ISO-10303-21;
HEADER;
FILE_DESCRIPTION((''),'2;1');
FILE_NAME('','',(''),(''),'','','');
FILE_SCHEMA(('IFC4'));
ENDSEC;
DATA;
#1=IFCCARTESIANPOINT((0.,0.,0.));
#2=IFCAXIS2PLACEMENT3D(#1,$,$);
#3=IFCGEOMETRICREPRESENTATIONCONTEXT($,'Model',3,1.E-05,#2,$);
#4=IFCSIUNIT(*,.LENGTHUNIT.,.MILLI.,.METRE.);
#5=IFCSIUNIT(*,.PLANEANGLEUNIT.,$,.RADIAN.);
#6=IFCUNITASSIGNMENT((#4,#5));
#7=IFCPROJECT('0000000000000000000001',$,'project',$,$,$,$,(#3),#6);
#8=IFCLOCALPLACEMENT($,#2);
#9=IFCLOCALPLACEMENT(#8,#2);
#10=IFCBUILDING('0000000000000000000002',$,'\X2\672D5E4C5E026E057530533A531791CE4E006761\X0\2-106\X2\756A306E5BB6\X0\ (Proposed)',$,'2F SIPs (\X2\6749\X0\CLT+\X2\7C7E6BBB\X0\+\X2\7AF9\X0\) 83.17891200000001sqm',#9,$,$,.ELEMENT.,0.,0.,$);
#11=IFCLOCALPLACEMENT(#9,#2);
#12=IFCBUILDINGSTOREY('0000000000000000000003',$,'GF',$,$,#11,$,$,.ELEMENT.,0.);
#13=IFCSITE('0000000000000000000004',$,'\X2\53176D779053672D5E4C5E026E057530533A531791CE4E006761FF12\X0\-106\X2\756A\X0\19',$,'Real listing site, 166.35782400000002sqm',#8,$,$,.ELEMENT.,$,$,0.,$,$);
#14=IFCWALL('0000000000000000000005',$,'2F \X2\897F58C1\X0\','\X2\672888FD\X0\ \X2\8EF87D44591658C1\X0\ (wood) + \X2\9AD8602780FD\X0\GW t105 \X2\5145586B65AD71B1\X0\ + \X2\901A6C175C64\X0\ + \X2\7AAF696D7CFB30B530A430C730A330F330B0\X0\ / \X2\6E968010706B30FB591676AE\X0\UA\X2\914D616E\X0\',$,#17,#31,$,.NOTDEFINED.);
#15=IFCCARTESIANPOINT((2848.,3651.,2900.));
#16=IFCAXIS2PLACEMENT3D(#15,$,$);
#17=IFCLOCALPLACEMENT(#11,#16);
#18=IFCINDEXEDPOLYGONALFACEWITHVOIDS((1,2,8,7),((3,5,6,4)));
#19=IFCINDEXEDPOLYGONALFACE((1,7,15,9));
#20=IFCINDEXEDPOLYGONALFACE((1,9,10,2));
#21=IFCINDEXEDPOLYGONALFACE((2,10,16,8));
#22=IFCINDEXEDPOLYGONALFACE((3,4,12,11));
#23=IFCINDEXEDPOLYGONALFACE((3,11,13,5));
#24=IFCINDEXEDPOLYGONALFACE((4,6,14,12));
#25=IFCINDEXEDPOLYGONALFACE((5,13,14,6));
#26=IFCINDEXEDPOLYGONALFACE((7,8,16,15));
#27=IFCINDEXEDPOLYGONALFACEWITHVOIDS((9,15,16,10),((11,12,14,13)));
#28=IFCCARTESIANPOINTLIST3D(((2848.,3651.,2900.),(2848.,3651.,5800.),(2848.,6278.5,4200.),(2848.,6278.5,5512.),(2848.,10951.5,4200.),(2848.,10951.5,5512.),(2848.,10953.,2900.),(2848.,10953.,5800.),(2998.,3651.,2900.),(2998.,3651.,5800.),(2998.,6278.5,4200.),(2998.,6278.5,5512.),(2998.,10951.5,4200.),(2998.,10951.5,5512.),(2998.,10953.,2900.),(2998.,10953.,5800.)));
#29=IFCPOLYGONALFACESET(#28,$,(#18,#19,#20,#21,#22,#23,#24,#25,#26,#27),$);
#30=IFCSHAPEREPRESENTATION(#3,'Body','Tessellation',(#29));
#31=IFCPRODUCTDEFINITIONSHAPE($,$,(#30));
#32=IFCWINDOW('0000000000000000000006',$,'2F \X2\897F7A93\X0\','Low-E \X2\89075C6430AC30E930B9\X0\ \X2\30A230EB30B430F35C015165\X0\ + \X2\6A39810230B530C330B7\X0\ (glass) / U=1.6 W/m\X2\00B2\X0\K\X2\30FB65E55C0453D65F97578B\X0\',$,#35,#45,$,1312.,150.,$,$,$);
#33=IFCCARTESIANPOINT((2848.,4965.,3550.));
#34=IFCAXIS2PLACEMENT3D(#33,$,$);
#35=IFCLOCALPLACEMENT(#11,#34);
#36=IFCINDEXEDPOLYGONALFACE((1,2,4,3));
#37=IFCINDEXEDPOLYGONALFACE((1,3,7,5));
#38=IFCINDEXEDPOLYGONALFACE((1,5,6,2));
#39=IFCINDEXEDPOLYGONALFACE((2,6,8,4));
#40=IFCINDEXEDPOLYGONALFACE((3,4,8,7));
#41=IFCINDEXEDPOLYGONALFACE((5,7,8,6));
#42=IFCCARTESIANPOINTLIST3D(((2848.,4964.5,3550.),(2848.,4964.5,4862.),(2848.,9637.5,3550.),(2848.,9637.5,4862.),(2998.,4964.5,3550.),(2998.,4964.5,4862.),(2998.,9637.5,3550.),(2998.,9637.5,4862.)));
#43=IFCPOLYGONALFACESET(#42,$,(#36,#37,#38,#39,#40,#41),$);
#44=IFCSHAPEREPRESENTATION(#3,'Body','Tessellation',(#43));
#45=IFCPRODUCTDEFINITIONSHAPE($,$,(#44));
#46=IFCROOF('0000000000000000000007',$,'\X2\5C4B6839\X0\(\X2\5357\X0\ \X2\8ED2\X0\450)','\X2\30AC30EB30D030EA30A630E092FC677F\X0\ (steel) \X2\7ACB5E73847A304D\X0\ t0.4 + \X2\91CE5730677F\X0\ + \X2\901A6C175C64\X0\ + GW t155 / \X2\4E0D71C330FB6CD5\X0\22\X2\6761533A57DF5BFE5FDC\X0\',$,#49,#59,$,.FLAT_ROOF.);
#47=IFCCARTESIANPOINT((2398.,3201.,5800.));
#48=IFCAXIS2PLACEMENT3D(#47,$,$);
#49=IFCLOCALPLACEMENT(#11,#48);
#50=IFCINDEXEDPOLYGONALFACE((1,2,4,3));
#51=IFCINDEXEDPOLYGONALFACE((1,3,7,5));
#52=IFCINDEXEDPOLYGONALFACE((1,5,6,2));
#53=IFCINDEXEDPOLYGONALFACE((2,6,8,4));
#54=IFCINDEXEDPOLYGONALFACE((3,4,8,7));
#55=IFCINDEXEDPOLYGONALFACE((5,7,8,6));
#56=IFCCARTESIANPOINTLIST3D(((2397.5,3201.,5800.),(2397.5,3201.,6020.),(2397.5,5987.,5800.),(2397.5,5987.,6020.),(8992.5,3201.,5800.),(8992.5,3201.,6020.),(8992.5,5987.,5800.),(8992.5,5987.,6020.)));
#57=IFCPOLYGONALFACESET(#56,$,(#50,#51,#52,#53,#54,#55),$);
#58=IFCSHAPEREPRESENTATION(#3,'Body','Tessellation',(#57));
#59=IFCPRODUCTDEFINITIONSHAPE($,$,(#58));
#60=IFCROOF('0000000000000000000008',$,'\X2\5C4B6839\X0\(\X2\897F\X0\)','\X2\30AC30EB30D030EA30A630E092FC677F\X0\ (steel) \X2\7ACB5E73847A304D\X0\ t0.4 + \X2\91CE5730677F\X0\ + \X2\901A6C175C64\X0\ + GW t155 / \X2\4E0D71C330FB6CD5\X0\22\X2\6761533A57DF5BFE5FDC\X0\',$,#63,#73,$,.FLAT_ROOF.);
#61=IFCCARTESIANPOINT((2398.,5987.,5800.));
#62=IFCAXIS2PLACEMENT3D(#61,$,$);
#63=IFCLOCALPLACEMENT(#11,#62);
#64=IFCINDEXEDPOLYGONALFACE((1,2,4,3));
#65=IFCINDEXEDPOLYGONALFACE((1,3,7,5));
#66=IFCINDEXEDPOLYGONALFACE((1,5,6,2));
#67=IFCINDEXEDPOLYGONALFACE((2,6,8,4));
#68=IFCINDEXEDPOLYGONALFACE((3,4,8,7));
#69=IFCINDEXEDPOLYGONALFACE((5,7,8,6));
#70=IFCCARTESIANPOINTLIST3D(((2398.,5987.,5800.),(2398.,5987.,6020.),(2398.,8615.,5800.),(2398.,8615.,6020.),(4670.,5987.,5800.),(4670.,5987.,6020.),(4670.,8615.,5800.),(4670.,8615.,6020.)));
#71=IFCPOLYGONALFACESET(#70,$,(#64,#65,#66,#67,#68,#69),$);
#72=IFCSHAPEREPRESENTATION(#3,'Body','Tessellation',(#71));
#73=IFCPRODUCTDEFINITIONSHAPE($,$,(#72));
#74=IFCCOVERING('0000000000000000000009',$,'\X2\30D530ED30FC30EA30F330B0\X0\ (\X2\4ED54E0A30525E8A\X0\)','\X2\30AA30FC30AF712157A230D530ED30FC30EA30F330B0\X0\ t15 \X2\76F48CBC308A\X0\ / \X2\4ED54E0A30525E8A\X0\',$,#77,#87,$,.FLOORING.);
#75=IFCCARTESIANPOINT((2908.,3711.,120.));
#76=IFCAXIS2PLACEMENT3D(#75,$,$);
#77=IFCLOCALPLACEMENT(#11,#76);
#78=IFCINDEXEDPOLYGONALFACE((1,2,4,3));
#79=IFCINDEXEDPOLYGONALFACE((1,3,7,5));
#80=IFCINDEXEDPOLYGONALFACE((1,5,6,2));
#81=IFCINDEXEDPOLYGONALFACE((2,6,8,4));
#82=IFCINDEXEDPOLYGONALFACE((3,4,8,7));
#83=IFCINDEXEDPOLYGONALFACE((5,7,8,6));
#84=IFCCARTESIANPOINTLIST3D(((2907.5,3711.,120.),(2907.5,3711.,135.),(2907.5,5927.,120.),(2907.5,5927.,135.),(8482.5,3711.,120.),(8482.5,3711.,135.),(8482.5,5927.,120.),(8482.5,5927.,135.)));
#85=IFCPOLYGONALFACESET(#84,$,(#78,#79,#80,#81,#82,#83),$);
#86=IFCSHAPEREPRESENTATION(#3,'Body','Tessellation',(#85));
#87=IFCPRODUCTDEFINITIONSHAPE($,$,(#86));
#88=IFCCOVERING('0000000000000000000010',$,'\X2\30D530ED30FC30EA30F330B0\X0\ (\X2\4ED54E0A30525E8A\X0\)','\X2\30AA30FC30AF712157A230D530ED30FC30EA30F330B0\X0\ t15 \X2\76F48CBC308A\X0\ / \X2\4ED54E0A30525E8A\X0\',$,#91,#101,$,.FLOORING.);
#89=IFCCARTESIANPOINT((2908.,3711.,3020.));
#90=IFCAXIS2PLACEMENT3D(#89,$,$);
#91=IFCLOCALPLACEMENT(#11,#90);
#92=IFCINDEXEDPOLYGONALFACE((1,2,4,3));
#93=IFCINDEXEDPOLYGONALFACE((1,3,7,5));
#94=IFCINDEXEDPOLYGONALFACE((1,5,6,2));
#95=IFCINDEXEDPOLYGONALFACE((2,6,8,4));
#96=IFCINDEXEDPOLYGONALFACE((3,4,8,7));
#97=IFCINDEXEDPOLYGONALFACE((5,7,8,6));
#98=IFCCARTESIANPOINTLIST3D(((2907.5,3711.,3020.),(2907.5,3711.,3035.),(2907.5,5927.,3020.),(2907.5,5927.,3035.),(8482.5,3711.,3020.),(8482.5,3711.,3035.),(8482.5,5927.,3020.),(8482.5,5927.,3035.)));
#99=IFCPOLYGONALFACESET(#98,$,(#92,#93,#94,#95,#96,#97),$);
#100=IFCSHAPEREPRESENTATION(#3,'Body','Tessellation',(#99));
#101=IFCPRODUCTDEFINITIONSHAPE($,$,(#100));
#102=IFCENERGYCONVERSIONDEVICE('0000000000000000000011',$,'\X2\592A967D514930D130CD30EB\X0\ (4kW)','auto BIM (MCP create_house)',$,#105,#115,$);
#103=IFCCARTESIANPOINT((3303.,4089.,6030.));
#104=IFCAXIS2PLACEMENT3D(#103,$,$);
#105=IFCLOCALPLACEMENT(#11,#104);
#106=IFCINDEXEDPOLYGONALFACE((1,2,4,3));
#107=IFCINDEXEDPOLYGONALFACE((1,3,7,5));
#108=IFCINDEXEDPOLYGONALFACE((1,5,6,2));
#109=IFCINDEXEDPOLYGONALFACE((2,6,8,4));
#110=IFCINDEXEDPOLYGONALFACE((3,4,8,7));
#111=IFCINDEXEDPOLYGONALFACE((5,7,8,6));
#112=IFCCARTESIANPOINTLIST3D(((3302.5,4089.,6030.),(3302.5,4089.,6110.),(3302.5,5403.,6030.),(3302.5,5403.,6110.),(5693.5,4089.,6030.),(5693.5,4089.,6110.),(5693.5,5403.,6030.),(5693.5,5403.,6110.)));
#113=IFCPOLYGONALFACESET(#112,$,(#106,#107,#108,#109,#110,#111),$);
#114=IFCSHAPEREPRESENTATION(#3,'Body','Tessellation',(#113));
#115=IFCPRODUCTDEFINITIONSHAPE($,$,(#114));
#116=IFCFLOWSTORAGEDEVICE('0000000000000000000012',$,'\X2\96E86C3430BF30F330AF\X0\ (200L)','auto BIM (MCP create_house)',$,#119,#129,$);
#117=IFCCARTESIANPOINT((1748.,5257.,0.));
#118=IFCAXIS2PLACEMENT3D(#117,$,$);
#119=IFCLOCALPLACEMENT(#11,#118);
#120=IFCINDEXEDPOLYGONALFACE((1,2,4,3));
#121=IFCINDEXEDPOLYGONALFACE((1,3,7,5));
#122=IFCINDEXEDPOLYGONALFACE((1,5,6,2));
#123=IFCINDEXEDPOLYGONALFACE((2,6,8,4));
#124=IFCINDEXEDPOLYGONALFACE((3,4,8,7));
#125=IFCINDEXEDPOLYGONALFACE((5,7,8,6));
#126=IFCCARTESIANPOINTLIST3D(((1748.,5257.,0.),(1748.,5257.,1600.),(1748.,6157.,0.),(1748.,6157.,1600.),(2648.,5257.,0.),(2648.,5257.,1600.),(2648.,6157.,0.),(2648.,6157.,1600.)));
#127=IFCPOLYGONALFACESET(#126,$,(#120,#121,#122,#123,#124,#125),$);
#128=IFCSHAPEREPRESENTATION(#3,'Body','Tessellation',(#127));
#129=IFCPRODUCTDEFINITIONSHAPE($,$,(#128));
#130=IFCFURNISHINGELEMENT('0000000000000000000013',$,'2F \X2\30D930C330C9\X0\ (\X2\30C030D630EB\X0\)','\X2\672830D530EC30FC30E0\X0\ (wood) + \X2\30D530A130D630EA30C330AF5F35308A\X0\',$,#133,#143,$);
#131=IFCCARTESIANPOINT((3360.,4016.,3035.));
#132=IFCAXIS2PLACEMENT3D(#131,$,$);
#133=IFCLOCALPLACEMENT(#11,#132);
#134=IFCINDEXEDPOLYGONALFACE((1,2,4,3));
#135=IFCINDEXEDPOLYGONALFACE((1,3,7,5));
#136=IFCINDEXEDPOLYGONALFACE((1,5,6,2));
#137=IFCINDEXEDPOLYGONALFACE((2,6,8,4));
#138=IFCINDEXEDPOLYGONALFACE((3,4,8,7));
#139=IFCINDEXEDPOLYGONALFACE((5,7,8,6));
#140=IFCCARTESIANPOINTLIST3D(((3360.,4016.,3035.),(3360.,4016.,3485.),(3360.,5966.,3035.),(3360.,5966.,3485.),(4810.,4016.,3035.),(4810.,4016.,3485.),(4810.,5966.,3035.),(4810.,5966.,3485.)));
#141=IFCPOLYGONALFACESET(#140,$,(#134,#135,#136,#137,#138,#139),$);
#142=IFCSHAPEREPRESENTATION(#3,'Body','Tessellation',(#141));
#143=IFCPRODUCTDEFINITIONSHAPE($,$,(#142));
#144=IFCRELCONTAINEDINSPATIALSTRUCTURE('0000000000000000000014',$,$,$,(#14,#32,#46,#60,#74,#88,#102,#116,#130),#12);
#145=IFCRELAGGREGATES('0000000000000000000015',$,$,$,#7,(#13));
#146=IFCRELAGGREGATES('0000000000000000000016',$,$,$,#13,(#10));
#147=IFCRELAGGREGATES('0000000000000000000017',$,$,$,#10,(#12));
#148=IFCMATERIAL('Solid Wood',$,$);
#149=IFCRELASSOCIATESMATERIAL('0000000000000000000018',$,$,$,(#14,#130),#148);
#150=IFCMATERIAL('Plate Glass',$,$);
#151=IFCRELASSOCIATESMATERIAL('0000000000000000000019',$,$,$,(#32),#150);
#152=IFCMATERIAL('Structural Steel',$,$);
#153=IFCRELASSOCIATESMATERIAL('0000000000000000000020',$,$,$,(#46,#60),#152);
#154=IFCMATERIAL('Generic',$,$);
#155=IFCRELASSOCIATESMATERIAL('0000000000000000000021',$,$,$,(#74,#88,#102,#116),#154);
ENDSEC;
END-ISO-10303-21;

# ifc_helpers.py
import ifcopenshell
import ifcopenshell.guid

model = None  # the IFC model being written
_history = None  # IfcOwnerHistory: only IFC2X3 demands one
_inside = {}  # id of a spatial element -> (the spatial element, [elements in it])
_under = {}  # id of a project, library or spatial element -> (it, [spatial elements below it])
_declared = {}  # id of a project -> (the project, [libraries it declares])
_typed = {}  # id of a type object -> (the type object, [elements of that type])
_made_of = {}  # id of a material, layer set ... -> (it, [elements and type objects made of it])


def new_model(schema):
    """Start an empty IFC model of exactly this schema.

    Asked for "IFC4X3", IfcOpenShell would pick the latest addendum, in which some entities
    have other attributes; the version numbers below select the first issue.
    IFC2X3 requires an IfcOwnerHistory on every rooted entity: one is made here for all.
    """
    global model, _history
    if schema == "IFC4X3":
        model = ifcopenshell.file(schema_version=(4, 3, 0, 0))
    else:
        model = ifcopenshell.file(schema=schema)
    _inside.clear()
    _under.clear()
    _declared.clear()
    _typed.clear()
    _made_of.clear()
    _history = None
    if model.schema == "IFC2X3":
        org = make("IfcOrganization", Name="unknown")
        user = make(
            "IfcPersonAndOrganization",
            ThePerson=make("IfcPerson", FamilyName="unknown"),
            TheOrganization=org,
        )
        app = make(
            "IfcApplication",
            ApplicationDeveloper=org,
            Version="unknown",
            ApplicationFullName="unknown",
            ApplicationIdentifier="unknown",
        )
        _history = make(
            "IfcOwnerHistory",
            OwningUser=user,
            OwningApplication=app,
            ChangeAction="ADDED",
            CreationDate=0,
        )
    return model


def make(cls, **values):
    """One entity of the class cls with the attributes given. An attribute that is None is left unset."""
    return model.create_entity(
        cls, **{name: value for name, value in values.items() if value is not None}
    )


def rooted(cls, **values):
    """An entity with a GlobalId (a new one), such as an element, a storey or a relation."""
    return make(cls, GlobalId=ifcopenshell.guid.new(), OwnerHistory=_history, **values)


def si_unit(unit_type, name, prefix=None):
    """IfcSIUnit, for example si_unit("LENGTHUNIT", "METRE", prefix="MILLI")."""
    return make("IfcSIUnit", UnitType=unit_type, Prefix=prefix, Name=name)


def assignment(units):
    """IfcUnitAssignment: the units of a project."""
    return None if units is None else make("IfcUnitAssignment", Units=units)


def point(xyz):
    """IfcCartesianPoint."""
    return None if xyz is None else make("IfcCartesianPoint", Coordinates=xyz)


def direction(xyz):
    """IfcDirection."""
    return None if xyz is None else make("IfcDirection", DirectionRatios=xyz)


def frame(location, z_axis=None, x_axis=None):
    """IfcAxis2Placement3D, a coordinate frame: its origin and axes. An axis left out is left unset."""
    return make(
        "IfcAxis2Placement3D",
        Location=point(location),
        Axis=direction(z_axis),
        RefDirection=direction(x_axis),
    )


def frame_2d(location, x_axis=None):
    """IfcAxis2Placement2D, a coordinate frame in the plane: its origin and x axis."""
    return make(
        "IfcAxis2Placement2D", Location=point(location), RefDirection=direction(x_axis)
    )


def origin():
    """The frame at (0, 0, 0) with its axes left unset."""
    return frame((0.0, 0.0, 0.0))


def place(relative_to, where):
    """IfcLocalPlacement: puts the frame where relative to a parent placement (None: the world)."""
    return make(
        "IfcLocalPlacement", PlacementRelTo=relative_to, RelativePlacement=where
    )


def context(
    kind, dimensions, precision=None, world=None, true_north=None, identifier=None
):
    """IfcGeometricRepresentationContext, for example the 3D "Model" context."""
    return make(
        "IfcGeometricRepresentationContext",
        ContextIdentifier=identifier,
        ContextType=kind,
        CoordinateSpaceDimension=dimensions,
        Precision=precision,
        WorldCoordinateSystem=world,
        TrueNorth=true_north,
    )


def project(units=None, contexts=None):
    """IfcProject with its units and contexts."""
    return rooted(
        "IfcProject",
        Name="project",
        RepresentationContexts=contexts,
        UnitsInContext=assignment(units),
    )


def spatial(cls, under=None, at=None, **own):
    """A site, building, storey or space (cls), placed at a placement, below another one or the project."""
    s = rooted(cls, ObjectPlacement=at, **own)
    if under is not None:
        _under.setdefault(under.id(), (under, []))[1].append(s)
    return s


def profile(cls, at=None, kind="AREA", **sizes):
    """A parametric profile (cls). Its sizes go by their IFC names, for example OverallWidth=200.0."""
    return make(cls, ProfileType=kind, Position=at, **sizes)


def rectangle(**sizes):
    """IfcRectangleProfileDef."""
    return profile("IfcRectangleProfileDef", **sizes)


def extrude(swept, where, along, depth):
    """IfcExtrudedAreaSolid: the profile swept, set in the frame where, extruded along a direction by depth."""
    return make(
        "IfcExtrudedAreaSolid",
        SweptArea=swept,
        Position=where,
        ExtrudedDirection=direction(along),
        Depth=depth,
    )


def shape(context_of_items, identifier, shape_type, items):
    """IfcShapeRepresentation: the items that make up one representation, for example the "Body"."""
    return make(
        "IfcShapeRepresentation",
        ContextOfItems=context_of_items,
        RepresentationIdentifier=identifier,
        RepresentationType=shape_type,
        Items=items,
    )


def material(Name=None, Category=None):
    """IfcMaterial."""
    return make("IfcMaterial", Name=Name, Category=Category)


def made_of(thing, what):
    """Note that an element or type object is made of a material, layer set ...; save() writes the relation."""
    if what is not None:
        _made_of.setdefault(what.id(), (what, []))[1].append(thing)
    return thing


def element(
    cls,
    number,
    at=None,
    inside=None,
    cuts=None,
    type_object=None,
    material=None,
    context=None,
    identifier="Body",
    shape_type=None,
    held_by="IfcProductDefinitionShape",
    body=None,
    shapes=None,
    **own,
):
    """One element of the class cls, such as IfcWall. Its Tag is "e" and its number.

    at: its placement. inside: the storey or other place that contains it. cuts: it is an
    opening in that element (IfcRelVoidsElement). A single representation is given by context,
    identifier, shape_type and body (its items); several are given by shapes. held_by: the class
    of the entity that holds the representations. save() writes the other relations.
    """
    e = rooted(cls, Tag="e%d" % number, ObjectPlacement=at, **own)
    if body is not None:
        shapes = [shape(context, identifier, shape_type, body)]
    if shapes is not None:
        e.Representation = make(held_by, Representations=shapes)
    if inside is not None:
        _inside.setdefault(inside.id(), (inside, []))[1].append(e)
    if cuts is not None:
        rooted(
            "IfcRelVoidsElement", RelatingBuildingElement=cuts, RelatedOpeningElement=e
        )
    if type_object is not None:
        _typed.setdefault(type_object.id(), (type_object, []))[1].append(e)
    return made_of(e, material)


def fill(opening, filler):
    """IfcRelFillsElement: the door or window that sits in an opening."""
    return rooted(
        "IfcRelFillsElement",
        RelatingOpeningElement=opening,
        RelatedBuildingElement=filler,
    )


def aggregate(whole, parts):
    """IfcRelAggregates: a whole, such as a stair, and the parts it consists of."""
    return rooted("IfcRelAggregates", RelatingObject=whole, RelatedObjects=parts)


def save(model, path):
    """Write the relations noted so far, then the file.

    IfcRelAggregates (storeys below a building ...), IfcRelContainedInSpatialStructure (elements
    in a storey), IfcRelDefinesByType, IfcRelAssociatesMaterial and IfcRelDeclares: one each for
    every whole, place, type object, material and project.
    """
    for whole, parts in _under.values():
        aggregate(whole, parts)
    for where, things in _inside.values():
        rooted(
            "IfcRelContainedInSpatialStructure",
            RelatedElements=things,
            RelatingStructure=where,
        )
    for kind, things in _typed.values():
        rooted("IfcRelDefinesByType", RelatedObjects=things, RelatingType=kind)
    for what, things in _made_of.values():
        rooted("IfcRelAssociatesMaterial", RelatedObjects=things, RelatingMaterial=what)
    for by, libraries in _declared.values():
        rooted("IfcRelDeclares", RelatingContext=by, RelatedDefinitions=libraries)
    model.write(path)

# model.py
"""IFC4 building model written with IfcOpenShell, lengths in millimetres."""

from ifc_helpers import new_model, si_unit, frame, frame_2d, origin, place, context, project, spatial, rectangle, extrude, material, element, fill, save


model = new_model("IFC4")

# Units and contexts
model_context = context("Model", 3, precision=1e-05, world=origin())
ifc_project = project(units=[si_unit("LENGTHUNIT", "METRE", prefix="MILLI"), si_unit("PLANEANGLEUNIT", "RADIAN")], contexts=[model_context])

# Site, building, storey
site_placement = place(None, origin())
site = spatial("IfcSite", under=ifc_project, at=site_placement, Name="北海道札幌市清田区北野一条２-106番19", ObjectType="Real listing site, 166.35782400000002sqm", CompositionType="ELEMENT", RefElevation=0.0)
building_placement = place(site_placement, origin())
building = spatial("IfcBuilding", under=site, at=building_placement, Name="札幌市清田区北野一条2-106番の家 (Proposed)", ObjectType="2F SIPs (杉CLT+籾殻+竹) 83.17891200000001sqm", CompositionType="ELEMENT", ElevationOfRefHeight=0.0, ElevationOfTerrain=0.0)
storey_placement = place(building_placement, origin())
storey = spatial("IfcBuildingStorey", under=building, at=storey_placement, Name="GF", CompositionType="ELEMENT", Elevation=0.0)

# Shared definitions
ifc_material_1 = material(Name="Solid Wood")

# Shared definitions
ifc_material_2 = material(Name="Plate Glass")

# Wall, opening, window
wall_1_placement = place(storey_placement, frame((2848.0, 3651.0, 2900.0)))
wall_1 = element("IfcWall", 1, at=wall_1_placement, inside=storey, material=ifc_material_1, Name="2F 西壁", Description="木製 軸組外壁 (wood) + 高性能GW t105 充填断熱 + 通気層 + 窯業系サイディング / 準耐火・外皮UA配慮", PredefinedType="NOTDEFINED", context=model_context, shape_type="SweptSolid", body=[
    extrude(rectangle(XDim=150.0, YDim=7302.0, at=frame_2d((75.0, 3651.0))), frame((2848.0, 3651.0, 2900.0)), (0.0, 0.0, 1.0), 2900.0),
])
opening_1_placement = place(storey_placement, frame((2848.0, 4965.0, 3550.0)))
opening_1 = element("IfcOpeningElement", 2, at=opening_1_placement, cuts=wall_1, PredefinedType="NOTDEFINED", context=model_context, shape_type="SweptSolid", body=[
    extrude(rectangle(XDim=150.0, YDim=4673.0, at=frame_2d((75.0, 2336.0))), frame((2848.0, 4965.0, 3550.0)), (0.0, 0.0, 1.0), 1312.0),
])
window_1_placement = place(storey_placement, frame((2848.0, 4965.0, 3550.0)))
window_1 = element("IfcWindow", 3, at=window_1_placement, inside=storey, material=ifc_material_2, Name="2F 西窓", Description="Low-E 複層ガラス アルゴン封入 + 樹脂サッシ (glass) / U=1.6 W/m²K・日射取得型", OverallHeight=1312.0, OverallWidth=150.0, context=model_context, shape_type="SweptSolid", body=[
    extrude(rectangle(XDim=150.0, YDim=4673.0, at=frame_2d((75.0, 2336.0))), frame((2848.0, 4965.0, 3550.0)), (0.0, 0.0, 1.0), 1312.0),
])
fill(opening_1, window_1)

# Roofs
ifc_material_3 = material(Name="Structural Steel")
roof_1_placement = place(storey_placement, frame((2398.0, 3201.0, 5800.0)))
element("IfcRoof", 4, at=roof_1_placement, inside=storey, material=ifc_material_3, Name="屋根(南 軒450)", Description="ガルバリウム鋼板 (steel) 立平葺き t0.4 + 野地板 + 通気層 + GW t155 / 不燃・法22条区域対応", PredefinedType="FLAT_ROOF", context=model_context, shape_type="SweptSolid", body=[
    extrude(rectangle(XDim=6595.0, YDim=2786.0, at=frame_2d((3297.0, 1393.0))), frame((2398.0, 3201.0, 5800.0)), (0.0, 0.0, 1.0), 220.0),
])
roof_2_placement = place(storey_placement, frame((2398.0, 5987.0, 5800.0)))
element("IfcRoof", 5, at=roof_2_placement, inside=storey, material=ifc_material_3, Name="屋根(西)", Description="ガルバリウム鋼板 (steel) 立平葺き t0.4 + 野地板 + 通気層 + GW t155 / 不燃・法22条区域対応", PredefinedType="FLAT_ROOF", context=model_context, shape_type="SweptSolid", body=[
    extrude(rectangle(XDim=2272.0, YDim=2628.0, at=frame_2d((1136.0, 1314.0))), frame((2398.0, 5987.0, 5800.0)), (0.0, 0.0, 1.0), 220.0),
])

# Coverings
ifc_material_4 = material(Name="Generic")
covering_1_placement = place(storey_placement, frame((2908.0, 3711.0, 120.0)))
element("IfcCovering", 6, at=covering_1_placement, inside=storey, material=ifc_material_4, Name="フローリング (仕上げ床)", Description="オーク無垢フローリング t15 直貼り / 仕上げ床", PredefinedType="FLOORING", context=model_context, shape_type="SweptSolid", body=[
    extrude(rectangle(XDim=5575.0, YDim=2216.0, at=frame_2d((2787.0, 1108.0))), frame((2908.0, 3711.0, 120.0)), (0.0, 0.0, 1.0), 15.0),
])
covering_2_placement = place(storey_placement, frame((2908.0, 3711.0, 3020.0)))
element("IfcCovering", 7, at=covering_2_placement, inside=storey, material=ifc_material_4, Name="フローリング (仕上げ床)", Description="オーク無垢フローリング t15 直貼り / 仕上げ床", PredefinedType="FLOORING", context=model_context, shape_type="SweptSolid", body=[
    extrude(rectangle(XDim=5575.0, YDim=2216.0, at=frame_2d((2787.0, 1108.0))), frame((2908.0, 3711.0, 3020.0)), (0.0, 0.0, 1.0), 15.0),
])

# Energy conversion device
energy_conversion_device_placement = place(storey_placement, frame((3303.0, 4089.0, 6030.0)))
element("IfcEnergyConversionDevice", 8, at=energy_conversion_device_placement, inside=storey, material=ifc_material_4, Name="太陽光パネル (4kW)", Description="auto BIM (MCP create_house)", context=model_context, shape_type="SweptSolid", body=[
    extrude(rectangle(XDim=2391.0, YDim=1314.0, at=frame_2d((1195.0, 657.0))), frame((3303.0, 4089.0, 6030.0)), (0.0, 0.0, 1.0), 80.0),
])

# Flow storage device
flow_storage_device_placement = place(storey_placement, frame((1748.0, 5257.0, 0.0)))
element("IfcFlowStorageDevice", 9, at=flow_storage_device_placement, inside=storey, material=ifc_material_4, Name="雨水タンク (200L)", Description="auto BIM (MCP create_house)", context=model_context, shape_type="SweptSolid", body=[
    extrude(rectangle(XDim=900.0, YDim=900.0, at=frame_2d((450.0, 450.0))), frame((1748.0, 5257.0, 0.0)), (0.0, 0.0, 1.0), 1600.0),
])

# Furnishing element
furnishing_placement = place(storey_placement, frame((3360.0, 4016.0, 3035.0)))
element("IfcFurnishingElement", 10, at=furnishing_placement, inside=storey, material=ifc_material_1, Name="2F ベッド (ダブル)", Description="木フレーム (wood) + ファブリック張り", context=model_context, shape_type="SweptSolid", body=[
    extrude(rectangle(XDim=1450.0, YDim=1950.0, at=frame_2d((725.0, 975.0))), frame((3360.0, 4016.0, 3035.0)), (0.0, 0.0, 1.0), 450.0),
])

save(model, "model.ifc")
